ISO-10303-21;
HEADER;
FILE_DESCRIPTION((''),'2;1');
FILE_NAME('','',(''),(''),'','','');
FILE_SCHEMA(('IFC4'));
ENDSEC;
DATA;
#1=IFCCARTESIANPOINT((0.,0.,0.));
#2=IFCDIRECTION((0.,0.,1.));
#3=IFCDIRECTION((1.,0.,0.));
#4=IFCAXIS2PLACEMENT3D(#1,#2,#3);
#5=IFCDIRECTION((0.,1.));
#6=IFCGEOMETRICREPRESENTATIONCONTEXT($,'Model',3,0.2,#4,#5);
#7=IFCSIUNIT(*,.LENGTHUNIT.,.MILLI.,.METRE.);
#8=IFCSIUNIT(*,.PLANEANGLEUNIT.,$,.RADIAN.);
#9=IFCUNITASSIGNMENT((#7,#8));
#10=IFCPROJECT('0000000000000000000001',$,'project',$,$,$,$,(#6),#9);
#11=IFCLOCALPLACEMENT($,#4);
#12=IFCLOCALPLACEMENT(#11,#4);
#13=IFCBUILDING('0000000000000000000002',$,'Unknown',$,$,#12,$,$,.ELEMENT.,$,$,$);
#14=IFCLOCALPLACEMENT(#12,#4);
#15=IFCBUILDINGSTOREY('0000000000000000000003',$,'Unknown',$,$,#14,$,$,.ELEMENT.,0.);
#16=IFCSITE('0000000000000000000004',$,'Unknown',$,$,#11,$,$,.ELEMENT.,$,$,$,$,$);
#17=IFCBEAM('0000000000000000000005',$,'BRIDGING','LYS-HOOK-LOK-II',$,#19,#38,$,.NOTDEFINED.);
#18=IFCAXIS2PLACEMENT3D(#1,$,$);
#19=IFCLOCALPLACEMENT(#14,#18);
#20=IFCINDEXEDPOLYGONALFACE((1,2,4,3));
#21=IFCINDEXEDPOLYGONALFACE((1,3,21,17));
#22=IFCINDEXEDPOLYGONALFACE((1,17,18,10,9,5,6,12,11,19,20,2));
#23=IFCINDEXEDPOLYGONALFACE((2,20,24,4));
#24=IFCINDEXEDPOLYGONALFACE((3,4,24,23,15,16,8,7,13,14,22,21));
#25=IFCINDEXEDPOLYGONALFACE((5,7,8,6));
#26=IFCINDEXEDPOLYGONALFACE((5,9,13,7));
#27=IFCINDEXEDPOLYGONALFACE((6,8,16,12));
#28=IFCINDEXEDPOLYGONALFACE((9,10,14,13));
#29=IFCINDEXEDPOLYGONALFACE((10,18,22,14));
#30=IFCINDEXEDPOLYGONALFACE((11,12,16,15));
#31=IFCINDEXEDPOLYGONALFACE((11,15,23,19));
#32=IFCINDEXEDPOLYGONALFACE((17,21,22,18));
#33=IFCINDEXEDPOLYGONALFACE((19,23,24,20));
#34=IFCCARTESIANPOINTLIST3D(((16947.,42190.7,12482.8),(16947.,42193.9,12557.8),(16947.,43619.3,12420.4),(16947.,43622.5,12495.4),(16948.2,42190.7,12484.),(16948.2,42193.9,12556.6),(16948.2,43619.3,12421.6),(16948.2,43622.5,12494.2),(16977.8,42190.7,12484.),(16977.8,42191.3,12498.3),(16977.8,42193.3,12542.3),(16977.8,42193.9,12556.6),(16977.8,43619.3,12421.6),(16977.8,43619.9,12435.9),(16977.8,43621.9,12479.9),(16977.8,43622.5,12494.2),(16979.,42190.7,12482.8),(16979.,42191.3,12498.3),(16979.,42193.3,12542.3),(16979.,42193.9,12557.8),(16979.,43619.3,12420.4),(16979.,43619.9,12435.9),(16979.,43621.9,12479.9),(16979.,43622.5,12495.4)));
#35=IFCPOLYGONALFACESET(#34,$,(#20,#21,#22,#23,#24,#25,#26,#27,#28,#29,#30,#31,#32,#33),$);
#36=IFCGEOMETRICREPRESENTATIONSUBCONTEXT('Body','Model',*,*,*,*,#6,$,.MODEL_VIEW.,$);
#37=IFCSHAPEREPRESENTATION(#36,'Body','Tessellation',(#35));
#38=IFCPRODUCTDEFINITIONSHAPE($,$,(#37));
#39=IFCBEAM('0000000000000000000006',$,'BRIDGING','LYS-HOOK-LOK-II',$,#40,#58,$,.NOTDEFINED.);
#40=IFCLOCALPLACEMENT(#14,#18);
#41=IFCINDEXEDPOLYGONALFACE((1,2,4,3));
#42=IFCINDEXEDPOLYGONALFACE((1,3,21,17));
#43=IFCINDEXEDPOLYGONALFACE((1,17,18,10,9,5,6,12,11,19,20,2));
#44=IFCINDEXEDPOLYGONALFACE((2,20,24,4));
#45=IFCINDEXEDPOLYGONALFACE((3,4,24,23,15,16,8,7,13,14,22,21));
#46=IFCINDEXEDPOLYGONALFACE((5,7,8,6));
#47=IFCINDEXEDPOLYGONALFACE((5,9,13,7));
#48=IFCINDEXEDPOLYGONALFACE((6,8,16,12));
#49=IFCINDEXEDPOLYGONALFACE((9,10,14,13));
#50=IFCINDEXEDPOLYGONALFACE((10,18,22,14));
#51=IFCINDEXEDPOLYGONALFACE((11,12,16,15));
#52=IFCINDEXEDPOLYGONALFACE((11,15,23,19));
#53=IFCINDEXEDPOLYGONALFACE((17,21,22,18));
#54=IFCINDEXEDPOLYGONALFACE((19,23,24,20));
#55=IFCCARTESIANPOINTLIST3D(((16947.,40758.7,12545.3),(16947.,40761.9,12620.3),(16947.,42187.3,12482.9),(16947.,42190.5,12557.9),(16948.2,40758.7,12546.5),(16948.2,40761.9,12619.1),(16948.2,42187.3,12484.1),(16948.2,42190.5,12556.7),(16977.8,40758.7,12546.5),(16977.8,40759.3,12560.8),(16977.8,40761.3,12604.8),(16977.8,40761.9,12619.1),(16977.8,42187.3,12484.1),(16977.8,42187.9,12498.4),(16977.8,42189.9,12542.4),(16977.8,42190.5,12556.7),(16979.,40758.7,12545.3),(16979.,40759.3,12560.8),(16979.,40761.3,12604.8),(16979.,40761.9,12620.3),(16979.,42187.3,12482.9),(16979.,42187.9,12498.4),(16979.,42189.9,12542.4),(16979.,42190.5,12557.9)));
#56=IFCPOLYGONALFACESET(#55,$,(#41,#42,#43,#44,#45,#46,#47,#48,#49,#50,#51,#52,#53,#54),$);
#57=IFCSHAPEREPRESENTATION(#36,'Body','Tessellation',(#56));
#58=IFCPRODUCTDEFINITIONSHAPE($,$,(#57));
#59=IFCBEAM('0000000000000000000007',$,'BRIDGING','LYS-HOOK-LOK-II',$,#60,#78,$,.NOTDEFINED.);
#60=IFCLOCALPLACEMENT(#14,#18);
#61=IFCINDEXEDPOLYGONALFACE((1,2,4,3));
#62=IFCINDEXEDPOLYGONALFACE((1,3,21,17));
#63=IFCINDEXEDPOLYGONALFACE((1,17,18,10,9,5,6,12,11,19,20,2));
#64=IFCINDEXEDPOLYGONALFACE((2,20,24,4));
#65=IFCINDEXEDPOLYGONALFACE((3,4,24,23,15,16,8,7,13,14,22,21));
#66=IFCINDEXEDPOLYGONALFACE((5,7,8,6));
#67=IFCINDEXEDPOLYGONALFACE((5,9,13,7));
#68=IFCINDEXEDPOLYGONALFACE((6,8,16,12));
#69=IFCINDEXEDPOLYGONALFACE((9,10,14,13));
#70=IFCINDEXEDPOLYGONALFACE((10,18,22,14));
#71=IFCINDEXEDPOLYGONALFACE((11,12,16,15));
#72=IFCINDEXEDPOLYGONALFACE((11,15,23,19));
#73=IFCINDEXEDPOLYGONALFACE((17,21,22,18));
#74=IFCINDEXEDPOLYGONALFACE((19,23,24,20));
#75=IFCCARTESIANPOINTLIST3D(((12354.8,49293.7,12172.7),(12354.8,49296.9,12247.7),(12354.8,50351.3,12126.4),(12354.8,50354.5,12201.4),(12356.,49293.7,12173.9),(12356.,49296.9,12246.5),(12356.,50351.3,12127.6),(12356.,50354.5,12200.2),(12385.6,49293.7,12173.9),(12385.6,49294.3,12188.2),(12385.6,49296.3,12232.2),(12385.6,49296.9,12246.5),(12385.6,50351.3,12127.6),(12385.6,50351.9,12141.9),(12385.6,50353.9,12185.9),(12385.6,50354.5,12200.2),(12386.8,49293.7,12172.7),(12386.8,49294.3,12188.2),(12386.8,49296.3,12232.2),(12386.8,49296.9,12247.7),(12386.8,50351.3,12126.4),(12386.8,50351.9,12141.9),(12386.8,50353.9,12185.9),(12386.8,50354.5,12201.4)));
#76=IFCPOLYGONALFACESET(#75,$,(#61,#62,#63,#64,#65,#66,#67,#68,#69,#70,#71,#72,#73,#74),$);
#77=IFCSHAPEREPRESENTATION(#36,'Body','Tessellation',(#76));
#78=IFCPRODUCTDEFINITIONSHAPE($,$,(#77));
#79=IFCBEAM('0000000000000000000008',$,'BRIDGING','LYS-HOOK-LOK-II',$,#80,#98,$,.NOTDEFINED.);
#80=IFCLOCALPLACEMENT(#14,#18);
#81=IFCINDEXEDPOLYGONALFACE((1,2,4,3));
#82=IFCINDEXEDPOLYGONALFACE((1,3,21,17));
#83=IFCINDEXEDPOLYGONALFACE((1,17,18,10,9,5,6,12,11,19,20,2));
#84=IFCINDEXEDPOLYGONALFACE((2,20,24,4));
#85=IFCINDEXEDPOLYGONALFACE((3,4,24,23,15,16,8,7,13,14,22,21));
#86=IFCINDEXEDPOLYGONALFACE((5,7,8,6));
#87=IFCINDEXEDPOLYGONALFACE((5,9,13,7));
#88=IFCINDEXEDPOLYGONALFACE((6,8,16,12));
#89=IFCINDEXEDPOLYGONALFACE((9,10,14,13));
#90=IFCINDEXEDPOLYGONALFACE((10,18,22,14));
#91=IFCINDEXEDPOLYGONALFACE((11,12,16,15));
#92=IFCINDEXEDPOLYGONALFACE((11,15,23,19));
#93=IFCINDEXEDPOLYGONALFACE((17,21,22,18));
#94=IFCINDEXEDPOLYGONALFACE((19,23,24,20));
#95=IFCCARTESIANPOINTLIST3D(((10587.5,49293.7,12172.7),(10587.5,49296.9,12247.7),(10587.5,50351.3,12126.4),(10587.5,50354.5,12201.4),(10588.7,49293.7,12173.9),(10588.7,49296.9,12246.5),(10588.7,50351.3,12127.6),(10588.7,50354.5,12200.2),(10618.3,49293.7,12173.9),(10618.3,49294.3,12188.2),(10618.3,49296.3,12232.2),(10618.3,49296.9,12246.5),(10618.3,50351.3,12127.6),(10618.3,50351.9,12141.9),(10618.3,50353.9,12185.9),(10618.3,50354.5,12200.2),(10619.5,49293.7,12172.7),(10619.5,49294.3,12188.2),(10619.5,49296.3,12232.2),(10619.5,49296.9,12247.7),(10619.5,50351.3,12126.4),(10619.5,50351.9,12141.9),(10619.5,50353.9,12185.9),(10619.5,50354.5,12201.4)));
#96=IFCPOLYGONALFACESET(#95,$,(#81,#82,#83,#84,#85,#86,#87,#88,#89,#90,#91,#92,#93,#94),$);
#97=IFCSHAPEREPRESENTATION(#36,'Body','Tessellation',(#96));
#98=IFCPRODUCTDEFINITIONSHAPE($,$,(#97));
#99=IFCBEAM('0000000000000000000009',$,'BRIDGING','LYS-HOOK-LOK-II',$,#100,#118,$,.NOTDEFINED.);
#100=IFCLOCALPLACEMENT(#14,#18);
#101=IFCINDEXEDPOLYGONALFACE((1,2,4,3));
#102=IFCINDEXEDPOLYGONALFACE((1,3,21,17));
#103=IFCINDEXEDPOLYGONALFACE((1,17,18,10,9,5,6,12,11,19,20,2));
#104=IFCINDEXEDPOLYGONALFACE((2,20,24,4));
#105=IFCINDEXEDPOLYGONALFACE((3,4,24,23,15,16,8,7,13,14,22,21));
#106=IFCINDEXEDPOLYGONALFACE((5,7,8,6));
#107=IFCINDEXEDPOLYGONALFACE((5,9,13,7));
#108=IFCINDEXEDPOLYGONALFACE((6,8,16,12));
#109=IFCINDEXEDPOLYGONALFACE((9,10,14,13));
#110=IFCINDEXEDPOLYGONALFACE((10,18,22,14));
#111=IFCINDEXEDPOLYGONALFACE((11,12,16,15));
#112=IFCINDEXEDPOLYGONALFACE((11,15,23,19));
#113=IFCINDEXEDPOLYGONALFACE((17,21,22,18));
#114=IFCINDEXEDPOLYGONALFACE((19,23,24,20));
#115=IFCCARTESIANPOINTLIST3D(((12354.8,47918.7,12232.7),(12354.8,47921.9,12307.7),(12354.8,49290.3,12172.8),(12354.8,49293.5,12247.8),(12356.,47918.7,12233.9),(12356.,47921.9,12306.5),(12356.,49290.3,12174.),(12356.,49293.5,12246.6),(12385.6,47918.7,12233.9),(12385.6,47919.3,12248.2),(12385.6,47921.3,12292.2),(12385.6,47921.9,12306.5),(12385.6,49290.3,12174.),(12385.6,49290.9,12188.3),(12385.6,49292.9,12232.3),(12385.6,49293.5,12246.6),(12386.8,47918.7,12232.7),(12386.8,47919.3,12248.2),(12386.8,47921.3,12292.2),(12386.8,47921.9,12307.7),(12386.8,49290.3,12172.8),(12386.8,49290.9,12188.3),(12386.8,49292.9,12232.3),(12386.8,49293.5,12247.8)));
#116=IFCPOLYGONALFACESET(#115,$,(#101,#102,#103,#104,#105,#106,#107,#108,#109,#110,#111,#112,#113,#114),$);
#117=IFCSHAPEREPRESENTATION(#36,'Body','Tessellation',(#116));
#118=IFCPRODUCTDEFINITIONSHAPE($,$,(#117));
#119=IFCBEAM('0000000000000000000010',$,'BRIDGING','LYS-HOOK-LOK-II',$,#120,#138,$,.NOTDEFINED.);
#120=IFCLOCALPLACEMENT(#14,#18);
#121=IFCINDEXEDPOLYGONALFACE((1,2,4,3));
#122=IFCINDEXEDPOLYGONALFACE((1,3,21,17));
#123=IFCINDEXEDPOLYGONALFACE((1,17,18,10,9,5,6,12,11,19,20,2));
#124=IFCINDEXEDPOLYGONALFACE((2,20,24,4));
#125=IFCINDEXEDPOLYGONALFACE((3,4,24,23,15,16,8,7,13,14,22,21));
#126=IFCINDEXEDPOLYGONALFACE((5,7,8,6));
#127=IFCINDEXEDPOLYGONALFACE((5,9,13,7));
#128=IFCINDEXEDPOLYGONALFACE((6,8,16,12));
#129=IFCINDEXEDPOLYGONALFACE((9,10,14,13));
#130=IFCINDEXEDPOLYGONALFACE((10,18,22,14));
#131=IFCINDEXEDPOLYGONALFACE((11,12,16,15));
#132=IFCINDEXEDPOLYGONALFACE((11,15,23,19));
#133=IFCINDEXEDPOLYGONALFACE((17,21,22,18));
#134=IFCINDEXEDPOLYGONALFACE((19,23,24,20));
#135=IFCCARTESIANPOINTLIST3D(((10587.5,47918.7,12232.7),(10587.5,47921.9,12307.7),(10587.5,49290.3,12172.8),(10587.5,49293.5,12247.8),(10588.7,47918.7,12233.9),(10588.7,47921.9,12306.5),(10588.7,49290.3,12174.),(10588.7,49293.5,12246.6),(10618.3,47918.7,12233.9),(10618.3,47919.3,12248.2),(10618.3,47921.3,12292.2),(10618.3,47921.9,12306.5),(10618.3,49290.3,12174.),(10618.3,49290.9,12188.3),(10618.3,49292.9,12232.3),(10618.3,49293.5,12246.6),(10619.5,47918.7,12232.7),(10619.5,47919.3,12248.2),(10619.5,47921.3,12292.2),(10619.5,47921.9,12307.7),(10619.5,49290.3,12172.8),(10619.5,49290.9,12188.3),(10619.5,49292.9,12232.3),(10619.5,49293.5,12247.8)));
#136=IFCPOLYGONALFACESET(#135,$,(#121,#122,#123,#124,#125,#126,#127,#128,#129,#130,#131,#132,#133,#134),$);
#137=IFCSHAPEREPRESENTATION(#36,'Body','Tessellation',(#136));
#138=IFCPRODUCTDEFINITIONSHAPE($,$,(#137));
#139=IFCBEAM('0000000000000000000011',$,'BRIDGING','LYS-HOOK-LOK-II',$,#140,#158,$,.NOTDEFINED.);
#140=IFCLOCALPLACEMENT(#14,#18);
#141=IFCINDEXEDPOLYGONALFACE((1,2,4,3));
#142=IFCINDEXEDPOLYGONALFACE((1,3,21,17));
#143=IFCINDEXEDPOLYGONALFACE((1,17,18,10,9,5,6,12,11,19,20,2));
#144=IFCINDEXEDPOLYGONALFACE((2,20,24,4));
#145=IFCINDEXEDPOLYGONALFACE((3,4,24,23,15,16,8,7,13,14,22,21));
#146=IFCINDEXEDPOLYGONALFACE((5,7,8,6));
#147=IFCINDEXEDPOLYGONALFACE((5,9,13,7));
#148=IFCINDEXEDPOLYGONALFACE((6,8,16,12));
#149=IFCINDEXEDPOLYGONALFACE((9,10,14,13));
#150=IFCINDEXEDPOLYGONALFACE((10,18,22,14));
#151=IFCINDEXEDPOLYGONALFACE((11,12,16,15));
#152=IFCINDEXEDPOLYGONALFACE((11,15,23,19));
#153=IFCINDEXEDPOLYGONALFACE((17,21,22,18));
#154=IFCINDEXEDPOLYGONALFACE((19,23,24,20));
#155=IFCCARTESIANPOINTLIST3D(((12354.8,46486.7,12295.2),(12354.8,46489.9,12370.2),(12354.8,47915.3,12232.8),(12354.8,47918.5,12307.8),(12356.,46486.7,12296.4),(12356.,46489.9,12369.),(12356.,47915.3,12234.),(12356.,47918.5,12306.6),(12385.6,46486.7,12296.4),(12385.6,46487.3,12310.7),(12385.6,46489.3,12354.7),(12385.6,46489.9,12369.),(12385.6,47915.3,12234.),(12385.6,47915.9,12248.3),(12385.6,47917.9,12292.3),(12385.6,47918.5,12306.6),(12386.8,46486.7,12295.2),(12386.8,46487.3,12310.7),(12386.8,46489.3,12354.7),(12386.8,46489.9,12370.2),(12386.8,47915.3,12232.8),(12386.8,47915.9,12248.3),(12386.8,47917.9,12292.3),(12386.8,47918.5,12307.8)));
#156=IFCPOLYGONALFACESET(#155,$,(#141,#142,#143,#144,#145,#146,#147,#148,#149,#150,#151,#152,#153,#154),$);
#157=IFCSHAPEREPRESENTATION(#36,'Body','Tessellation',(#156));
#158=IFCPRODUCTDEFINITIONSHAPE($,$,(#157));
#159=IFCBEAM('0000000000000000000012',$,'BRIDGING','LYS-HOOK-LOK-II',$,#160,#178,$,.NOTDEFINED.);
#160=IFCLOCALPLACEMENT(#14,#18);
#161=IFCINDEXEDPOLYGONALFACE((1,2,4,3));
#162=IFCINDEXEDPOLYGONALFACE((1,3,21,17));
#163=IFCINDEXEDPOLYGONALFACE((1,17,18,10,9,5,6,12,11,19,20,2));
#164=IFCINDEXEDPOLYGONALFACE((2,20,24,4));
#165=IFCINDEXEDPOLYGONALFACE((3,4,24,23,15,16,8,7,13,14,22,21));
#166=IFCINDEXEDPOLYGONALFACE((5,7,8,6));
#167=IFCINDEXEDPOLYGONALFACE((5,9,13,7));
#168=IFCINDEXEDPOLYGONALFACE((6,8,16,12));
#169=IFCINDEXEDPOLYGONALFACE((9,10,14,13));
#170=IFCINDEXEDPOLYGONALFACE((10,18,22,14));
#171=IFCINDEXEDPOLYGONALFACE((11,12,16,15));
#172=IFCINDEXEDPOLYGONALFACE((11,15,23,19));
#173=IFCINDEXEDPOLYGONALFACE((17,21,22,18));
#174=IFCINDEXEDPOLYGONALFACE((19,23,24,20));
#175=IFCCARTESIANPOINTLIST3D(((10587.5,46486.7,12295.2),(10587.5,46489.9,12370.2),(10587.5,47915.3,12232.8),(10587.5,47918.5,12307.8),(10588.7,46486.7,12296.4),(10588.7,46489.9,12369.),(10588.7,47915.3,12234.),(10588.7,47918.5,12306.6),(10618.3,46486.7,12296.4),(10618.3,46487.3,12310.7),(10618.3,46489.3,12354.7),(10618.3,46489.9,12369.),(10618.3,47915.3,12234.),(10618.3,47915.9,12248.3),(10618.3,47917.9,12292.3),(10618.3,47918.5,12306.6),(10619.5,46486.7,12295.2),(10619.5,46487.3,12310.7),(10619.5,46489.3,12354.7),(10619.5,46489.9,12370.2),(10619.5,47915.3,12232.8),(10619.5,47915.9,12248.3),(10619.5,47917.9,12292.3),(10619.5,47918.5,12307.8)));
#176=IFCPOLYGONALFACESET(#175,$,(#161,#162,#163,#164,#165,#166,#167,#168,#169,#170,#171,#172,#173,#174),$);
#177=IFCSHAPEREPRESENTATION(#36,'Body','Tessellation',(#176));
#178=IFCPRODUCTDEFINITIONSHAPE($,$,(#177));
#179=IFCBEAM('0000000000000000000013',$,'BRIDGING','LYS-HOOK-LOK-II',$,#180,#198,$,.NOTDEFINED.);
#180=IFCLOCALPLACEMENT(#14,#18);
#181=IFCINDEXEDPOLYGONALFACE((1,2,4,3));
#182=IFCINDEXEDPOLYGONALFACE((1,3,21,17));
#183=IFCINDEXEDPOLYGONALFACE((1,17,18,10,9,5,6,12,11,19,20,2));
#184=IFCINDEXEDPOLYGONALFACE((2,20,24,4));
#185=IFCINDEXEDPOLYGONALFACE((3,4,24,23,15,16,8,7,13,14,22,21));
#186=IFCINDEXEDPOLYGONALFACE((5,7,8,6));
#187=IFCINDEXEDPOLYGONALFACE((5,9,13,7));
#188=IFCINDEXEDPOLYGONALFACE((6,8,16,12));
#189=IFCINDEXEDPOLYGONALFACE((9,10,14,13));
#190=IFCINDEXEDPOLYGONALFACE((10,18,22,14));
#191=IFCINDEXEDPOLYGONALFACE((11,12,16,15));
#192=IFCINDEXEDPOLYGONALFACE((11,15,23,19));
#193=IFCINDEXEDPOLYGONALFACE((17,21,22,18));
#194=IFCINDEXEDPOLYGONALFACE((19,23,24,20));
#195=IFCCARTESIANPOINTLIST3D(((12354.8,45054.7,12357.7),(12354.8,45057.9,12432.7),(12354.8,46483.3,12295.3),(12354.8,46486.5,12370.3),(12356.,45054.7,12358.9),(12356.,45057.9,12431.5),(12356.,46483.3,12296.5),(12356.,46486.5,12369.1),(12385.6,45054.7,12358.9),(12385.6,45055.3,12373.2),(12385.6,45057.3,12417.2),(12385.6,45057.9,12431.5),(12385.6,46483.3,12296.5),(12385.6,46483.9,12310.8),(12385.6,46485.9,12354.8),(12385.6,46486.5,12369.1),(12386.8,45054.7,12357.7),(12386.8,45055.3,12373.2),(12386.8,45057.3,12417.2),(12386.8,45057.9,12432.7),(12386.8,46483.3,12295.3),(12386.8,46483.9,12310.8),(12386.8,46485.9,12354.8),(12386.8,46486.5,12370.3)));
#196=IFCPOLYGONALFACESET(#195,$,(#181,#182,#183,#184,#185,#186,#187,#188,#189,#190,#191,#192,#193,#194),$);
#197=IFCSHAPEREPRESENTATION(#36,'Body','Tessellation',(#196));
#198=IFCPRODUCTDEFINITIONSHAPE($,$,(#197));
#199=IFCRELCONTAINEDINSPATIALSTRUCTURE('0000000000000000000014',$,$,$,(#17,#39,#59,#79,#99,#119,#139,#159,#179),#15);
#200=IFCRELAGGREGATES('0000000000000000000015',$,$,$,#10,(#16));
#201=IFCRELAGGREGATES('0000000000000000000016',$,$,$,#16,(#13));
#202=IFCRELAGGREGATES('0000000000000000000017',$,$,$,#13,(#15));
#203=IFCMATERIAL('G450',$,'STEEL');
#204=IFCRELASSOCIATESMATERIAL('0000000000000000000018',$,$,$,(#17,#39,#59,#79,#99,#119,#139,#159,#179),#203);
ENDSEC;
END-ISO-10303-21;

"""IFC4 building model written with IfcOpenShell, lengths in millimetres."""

from ifc_helpers import new_model, si_unit, direction, frame, origin_with_axes, place, context, subcontext, project, spatial, line, indexed_curve, outline, extrude, material, element, save


model = new_model("IFC4")

# Units and contexts
model_context = context("Model", 3, precision=0.2, world=origin_with_axes(), true_north=direction((0.0, 1.0)))
body_context = subcontext(model_context, "Body", "Model", "MODEL_VIEW")
ifc_project = project(units=[si_unit("LENGTHUNIT", "METRE", prefix="MILLI"), si_unit("PLANEANGLEUNIT", "RADIAN")], contexts=[model_context])

# Site, building, storey
site_placement = place(None, origin_with_axes())
site = spatial("IfcSite", under=ifc_project, at=site_placement, Name="Unknown", CompositionType="ELEMENT")
building_placement = place(site_placement, origin_with_axes())
building = spatial("IfcBuilding", under=site, at=building_placement, Name="Unknown", CompositionType="ELEMENT")
storey_placement = place(building_placement, origin_with_axes())
storey = spatial("IfcBuildingStorey", under=building, at=storey_placement, Name="Unknown", CompositionType="ELEMENT", Elevation=0.0)

# Beams
ifc_material_1 = material(Name="G450", Category="STEEL")
for number, where, z_axis, x_axis, name in (
    (1, (16963.0, 42192.3, 12520.3), (1.0, 0.0, 0.0), (0.0, 0.999047, -0.043638), "BRIDGING"),
    (2, (16963.0, 40760.3, 12582.8), (1.0, 0.0, 0.0), (0.0, 0.999047, -0.043638), "BRIDGING"),
):
    element("IfcBeam", number, at=place(storey_placement, frame(where, z_axis=z_axis, x_axis=x_axis)), inside=storey, material=ifc_material_1, Name=name, Description="LYS-HOOK-LOK-II", PredefinedType="NOTDEFINED", context=body_context, shape_type="SolidModel", body=[
        extrude(outline(indexed_curve([(16.0, -37.5), (16.0, -22.0), (14.8, -22.0), (14.8, -36.3), (-14.8, -36.3), (-14.8, 36.3), (14.8, 36.3), (14.8, 22.0), (16.0, 22.0), (16.0, 37.5), (-16.0, 37.5), (-16.0, -37.5)], segments=[line(1, 2, 3, 4, 5, 6, 7, 8, 9, 10, 11, 12, 1)])), frame((0.0, 0.0, 0.0), z_axis=(-1.0, 0.0, 0.0), x_axis=(0.0, 0.0, 1.0)), (0.0, 0.0, -1.0), 1430.0),
    ])
for number, where, z_axis, x_axis, name in (
    (3, (12370.8, 49295.3, 12210.2), (1.0, 0.0, 0.0), (0.0, 0.999043, -0.043736), "BRIDGING"),
    (4, (10603.5, 49295.3, 12210.2), (1.0, 0.0, 0.0), (0.0, 0.999043, -0.043736), "BRIDGING"),
):
    element("IfcBeam", number, at=place(storey_placement, frame(where, z_axis=z_axis, x_axis=x_axis)), inside=storey, material=ifc_material_1, Name=name, Description="LYS-HOOK-LOK-II", PredefinedType="NOTDEFINED", context=body_context, shape_type="SolidModel", body=[
        extrude(outline(indexed_curve([(16.0, -37.5), (16.0, -22.0), (14.8, -22.0), (14.8, -36.3), (-14.8, -36.3), (-14.8, 36.3), (14.8, 36.3), (14.8, 22.0), (16.0, 22.0), (16.0, 37.5), (-16.0, 37.5), (-16.0, -37.5)], segments=[line(1, 2, 3, 4, 5, 6, 7, 8, 9, 10, 11, 12, 1)])), frame((0.0, 0.0, 0.0), z_axis=(-1.0, 0.0, 0.0), x_axis=(0.0, 0.0, 1.0)), (0.0, 0.0, -1.0), 1058.6),
    ])
for number, where, z_axis, x_axis, name in (
    (5, (12370.8, 47920.3, 12270.2), (1.0, 0.0, 0.0), (0.0, 0.999048, -0.04363), "BRIDGING"),
    (6, (10603.5, 47920.3, 12270.2), (1.0, 0.0, 0.0), (0.0, 0.999048, -0.04363), "BRIDGING"),
):
    element("IfcBeam", number, at=place(storey_placement, frame(where, z_axis=z_axis, x_axis=x_axis)), inside=storey, material=ifc_material_1, Name=name, Description="LYS-HOOK-LOK-II", PredefinedType="NOTDEFINED", context=body_context, shape_type="SolidModel", body=[
        extrude(outline(indexed_curve([(16.0, -37.5), (16.0, -22.0), (14.8, -22.0), (14.8, -36.3), (-14.8, -36.3), (-14.8, 36.3), (14.8, 36.3), (14.8, 22.0), (16.0, 22.0), (16.0, 37.5), (-16.0, 37.5), (-16.0, -37.5)], segments=[line(1, 2, 3, 4, 5, 6, 7, 8, 9, 10, 11, 12, 1)])), frame((0.0, 0.0, 0.0), z_axis=(-1.0, 0.0, 0.0), x_axis=(0.0, 0.0, 1.0)), (0.0, 0.0, -1.0), 1372.9),
    ])
for number, where, z_axis, x_axis, name in (
    (7, (12370.8, 46488.3, 12332.7), (1.0, 0.0, 0.0), (0.0, 0.999047, -0.043638), "BRIDGING"),
    (8, (10603.5, 46488.3, 12332.7), (1.0, 0.0, 0.0), (0.0, 0.999047, -0.043638), "BRIDGING"),
    (9, (12370.8, 45056.3, 12395.2), (1.0, 0.0, 0.0), (0.0, 0.999047, -0.043638), "BRIDGING"),
):
    element("IfcBeam", number, at=place(storey_placement, frame(where, z_axis=z_axis, x_axis=x_axis)), inside=storey, material=ifc_material_1, Name=name, Description="LYS-HOOK-LOK-II", PredefinedType="NOTDEFINED", context=body_context, shape_type="SolidModel", body=[
        extrude(outline(indexed_curve([(16.0, -37.5), (16.0, -22.0), (14.8, -22.0), (14.8, -36.3), (-14.8, -36.3), (-14.8, 36.3), (14.8, 36.3), (14.8, 22.0), (16.0, 22.0), (16.0, 37.5), (-16.0, 37.5), (-16.0, -37.5)], segments=[line(1, 2, 3, 4, 5, 6, 7, 8, 9, 10, 11, 12, 1)])), frame((0.0, 0.0, 0.0), z_axis=(-1.0, 0.0, 0.0), x_axis=(0.0, 0.0, 1.0)), (0.0, 0.0, -1.0), 1430.0),
    ])

save(model, "model.ifc")
